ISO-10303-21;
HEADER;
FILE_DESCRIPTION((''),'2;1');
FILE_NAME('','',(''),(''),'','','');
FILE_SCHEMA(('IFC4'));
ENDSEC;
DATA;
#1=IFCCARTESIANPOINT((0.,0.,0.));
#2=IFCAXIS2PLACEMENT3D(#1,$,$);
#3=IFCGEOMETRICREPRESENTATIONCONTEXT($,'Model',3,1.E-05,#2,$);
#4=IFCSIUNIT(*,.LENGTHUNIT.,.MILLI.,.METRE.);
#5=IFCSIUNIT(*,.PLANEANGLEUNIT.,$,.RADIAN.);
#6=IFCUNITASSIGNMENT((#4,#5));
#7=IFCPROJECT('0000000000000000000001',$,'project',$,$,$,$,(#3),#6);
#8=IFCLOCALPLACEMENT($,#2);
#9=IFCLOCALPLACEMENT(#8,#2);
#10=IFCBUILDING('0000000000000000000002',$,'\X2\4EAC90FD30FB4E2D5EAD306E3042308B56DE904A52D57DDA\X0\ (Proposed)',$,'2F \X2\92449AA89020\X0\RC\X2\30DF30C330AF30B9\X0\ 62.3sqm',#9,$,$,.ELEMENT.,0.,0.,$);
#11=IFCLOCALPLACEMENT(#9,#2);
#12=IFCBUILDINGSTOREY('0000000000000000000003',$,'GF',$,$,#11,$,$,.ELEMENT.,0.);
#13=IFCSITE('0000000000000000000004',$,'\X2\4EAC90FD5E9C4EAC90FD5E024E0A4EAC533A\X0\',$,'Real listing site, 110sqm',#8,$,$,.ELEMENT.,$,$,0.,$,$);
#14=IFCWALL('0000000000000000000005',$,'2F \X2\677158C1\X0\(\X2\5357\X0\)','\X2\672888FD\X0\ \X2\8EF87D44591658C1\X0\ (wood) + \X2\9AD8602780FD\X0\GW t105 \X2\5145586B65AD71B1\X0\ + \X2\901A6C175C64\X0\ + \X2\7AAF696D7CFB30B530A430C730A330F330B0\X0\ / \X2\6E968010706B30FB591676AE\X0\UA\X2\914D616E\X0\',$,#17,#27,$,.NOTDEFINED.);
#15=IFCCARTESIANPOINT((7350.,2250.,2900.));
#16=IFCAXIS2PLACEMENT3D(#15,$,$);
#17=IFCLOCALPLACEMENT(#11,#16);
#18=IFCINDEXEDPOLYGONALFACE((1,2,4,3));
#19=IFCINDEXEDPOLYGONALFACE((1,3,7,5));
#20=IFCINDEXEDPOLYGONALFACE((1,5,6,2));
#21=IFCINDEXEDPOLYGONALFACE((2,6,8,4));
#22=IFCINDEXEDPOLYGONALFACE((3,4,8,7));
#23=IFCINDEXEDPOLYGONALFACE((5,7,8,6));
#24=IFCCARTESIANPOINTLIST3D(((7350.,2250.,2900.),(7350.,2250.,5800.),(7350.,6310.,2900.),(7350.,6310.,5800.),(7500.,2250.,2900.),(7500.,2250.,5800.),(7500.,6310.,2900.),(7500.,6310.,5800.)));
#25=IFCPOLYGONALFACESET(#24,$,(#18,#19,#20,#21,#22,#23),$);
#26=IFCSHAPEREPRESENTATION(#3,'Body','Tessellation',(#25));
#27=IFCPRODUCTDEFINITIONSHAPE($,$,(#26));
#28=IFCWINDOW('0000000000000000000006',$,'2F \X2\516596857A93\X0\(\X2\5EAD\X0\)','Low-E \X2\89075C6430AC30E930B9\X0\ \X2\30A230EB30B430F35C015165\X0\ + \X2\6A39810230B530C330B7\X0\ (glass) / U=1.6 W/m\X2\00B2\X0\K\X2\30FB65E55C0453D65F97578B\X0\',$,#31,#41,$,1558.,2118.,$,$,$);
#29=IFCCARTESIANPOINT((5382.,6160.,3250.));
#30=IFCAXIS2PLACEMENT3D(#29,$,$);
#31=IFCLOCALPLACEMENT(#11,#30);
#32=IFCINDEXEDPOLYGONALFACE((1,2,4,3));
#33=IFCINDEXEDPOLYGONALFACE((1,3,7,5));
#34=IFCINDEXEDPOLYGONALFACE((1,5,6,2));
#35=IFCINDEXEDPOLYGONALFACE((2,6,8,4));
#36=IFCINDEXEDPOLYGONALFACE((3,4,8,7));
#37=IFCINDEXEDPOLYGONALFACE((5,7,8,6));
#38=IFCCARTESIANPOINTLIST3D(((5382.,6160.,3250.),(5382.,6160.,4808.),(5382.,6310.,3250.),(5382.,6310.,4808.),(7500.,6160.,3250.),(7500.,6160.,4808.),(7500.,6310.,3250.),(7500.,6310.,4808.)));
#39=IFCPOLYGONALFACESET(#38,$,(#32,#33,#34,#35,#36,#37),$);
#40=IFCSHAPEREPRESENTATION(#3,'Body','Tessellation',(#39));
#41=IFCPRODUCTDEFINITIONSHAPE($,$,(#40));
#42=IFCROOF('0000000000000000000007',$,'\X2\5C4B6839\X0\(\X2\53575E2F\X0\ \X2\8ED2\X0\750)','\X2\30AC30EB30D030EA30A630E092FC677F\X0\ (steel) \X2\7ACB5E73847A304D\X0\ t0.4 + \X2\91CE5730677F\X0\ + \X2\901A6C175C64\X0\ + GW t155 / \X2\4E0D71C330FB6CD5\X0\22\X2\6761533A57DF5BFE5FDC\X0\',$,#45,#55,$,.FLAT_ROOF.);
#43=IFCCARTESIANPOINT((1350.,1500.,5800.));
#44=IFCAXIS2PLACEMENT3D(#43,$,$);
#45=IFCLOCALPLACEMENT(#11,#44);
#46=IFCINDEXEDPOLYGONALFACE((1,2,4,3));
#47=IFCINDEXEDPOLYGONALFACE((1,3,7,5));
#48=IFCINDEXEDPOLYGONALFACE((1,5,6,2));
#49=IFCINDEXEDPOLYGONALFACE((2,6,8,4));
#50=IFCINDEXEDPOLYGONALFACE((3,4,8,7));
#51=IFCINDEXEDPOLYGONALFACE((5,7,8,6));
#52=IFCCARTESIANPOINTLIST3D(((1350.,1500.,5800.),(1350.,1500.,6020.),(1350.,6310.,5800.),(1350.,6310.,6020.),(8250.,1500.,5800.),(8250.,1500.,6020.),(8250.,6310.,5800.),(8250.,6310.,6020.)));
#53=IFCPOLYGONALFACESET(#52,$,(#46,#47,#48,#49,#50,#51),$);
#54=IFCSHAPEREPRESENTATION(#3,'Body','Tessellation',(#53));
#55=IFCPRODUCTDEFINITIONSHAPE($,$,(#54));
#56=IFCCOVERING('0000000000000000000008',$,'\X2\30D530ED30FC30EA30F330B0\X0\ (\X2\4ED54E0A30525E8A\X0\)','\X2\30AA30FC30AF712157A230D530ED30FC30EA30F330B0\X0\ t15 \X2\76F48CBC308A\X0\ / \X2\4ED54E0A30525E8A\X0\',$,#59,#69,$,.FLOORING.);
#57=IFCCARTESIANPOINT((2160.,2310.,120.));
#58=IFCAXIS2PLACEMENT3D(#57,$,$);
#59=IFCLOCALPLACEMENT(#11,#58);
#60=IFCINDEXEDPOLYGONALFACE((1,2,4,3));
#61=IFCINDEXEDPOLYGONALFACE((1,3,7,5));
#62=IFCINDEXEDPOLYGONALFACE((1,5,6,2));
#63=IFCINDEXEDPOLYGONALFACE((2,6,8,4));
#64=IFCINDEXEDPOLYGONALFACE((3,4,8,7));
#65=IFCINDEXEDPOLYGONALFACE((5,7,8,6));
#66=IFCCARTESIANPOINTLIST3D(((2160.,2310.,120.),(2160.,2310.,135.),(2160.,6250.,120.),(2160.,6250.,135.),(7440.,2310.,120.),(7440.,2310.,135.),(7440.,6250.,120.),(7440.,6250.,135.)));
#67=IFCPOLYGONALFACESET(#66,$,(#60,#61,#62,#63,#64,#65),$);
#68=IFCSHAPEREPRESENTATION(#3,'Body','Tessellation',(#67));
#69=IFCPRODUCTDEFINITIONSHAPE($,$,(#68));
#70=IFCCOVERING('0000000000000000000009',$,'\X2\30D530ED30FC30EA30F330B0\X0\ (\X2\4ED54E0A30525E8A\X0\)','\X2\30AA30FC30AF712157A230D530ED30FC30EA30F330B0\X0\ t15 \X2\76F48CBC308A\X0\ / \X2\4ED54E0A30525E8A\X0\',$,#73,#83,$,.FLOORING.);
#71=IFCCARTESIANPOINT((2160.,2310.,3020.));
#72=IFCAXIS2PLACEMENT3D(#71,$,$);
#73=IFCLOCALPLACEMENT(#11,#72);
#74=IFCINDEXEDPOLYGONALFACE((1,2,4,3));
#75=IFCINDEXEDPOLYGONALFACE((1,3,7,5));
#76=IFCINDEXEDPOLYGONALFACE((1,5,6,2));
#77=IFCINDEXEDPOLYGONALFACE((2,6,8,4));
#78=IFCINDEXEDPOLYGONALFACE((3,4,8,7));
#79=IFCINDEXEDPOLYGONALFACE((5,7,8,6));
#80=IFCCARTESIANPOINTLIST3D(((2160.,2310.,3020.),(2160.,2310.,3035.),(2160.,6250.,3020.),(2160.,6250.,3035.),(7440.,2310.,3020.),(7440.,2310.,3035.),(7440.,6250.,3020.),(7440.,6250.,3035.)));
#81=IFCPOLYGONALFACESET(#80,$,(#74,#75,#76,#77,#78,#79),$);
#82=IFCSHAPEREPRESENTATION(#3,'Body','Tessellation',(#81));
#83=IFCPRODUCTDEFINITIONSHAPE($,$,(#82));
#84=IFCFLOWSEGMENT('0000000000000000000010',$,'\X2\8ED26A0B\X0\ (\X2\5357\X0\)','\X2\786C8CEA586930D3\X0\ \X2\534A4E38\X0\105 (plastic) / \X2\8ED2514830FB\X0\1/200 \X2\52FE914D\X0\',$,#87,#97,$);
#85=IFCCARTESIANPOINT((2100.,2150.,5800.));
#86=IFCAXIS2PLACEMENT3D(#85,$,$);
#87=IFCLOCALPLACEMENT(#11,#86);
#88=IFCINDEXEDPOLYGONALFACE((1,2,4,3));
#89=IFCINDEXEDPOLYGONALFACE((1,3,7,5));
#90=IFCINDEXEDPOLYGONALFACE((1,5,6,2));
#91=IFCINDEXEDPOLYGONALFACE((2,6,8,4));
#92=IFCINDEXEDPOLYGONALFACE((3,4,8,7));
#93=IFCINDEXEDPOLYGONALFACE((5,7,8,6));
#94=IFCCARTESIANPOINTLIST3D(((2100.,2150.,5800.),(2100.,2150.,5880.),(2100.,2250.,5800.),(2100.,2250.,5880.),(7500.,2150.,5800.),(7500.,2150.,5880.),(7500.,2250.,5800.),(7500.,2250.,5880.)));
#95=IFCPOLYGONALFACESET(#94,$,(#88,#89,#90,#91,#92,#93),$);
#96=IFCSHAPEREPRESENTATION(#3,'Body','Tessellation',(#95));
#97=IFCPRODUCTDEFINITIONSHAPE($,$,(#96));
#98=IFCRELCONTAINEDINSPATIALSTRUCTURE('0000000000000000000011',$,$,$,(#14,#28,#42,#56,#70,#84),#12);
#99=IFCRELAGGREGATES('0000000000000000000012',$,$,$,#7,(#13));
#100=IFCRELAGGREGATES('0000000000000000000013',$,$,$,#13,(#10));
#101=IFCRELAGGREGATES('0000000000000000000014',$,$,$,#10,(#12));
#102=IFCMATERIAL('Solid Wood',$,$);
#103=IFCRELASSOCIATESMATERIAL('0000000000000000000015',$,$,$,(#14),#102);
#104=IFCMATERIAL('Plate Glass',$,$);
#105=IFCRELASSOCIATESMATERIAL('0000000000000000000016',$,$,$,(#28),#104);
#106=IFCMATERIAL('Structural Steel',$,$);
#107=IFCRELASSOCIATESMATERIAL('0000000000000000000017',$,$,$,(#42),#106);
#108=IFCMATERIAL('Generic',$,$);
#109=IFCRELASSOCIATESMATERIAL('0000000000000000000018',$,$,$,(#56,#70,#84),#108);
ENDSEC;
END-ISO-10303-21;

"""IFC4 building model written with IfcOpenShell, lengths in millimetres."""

from ifc_helpers import new_model, si_unit, frame, frame_2d, origin, place, context, project, spatial, rectangle, extrude, material, element, fill, save


model = new_model("IFC4")

# Units and contexts
model_context = context("Model", 3, precision=1e-05, world=origin())
ifc_project = project(units=[si_unit("LENGTHUNIT", "METRE", prefix="MILLI"), si_unit("PLANEANGLEUNIT", "RADIAN")], contexts=[model_context])

# Site, building, storey
site_placement = place(None, origin())
site = spatial("IfcSite", under=ifc_project, at=site_placement, Name="京都府京都市上京区", ObjectType="Real listing site, 110sqm", CompositionType="ELEMENT", RefElevation=0.0)
building_placement = place(site_placement, origin())
building = spatial("IfcBuilding", under=site, at=building_placement, Name="京都・中庭のある回遊動線 (Proposed)", ObjectType="2F 鉄骨造RCミックス 62.3sqm", CompositionType="ELEMENT", ElevationOfRefHeight=0.0, ElevationOfTerrain=0.0)
storey_placement = place(building_placement, origin())
storey = spatial("IfcBuildingStorey", under=building, at=storey_placement, Name="GF", CompositionType="ELEMENT", Elevation=0.0)

# Shared definitions
ifc_material_1 = material(Name="Solid Wood")

# Wall, opening, window
ifc_material_2 = material(Name="Plate Glass")
wall_1_placement = place(storey_placement, frame((7350.0, 2250.0, 2900.0)))
wall_1 = element("IfcWall", 1, at=wall_1_placement, inside=storey, material=ifc_material_1, Name="2F 東壁(南)", Description="木製 軸組外壁 (wood) + 高性能GW t105 充填断熱 + 通気層 + 窯業系サイディング / 準耐火・外皮UA配慮", PredefinedType="NOTDEFINED", context=model_context, shape_type="SweptSolid", body=[
    extrude(rectangle(XDim=150.0, YDim=4060.0, at=frame_2d((75.0, 2030.0))), frame((7350.0, 2250.0, 2900.0)), (0.0, 0.0, 1.0), 2900.0),
])
opening_1_placement = place(storey_placement, frame((5382.0, 6160.0, 3250.0)))
opening_1 = element("IfcOpeningElement", 2, at=opening_1_placement, cuts=wall_1, PredefinedType="NOTDEFINED", context=model_context, shape_type="SweptSolid", body=[
    extrude(rectangle(XDim=2118.0, YDim=150.0, at=frame_2d((1059.0, 75.0))), frame((5382.0, 6160.0, 3250.0)), (0.0, 0.0, 1.0), 1558.0),
])
window_1_placement = place(storey_placement, frame((5382.0, 6160.0, 3250.0)))
window_1 = element("IfcWindow", 3, at=window_1_placement, inside=storey, material=ifc_material_2, Name="2F 入隅窓(庭)", Description="Low-E 複層ガラス アルゴン封入 + 樹脂サッシ (glass) / U=1.6 W/m²K・日射取得型", OverallHeight=1558.0, OverallWidth=2118.0, context=model_context, shape_type="SweptSolid", body=[
    extrude(rectangle(XDim=2118.0, YDim=150.0, at=frame_2d((1059.0, 75.0))), frame((5382.0, 6160.0, 3250.0)), (0.0, 0.0, 1.0), 1558.0),
])
fill(opening_1, window_1)

# Roof
ifc_material_3 = material(Name="Structural Steel")
for number, where, name in (
    (4, (1350.0, 1500.0, 5800.0), "屋根(南帯 軒750)"),
):
    element("IfcRoof", number, at=place(storey_placement, frame(where)), inside=storey, material=ifc_material_3, Name=name, Description="ガルバリウム鋼板 (steel) 立平葺き t0.4 + 野地板 + 通気層 + GW t155 / 不燃・法22条区域対応", PredefinedType="FLAT_ROOF", context=model_context, shape_type="SweptSolid", body=[
        extrude(rectangle(XDim=6900.0, YDim=4810.0, at=frame_2d((3450.0, 2405.0))), frame((1350.0, 1500.0, 5800.0)), (0.0, 0.0, 1.0), 220.0),
    ])

# Coverings
ifc_material_4 = material(Name="Generic")
covering_1_placement = place(storey_placement, frame((2160.0, 2310.0, 120.0)))
element("IfcCovering", 5, at=covering_1_placement, inside=storey, material=ifc_material_4, Name="フローリング (仕上げ床)", Description="オーク無垢フローリング t15 直貼り / 仕上げ床", PredefinedType="FLOORING", context=model_context, shape_type="SweptSolid", body=[
    extrude(rectangle(XDim=5280.0, YDim=3940.0, at=frame_2d((2640.0, 1970.0))), frame((2160.0, 2310.0, 120.0)), (0.0, 0.0, 1.0), 15.0),
])
covering_2_placement = place(storey_placement, frame((2160.0, 2310.0, 3020.0)))
element("IfcCovering", 6, at=covering_2_placement, inside=storey, material=ifc_material_4, Name="フローリング (仕上げ床)", Description="オーク無垢フローリング t15 直貼り / 仕上げ床", PredefinedType="FLOORING", context=model_context, shape_type="SweptSolid", body=[
    extrude(rectangle(XDim=5280.0, YDim=3940.0, at=frame_2d((2640.0, 1970.0))), frame((2160.0, 2310.0, 3020.0)), (0.0, 0.0, 1.0), 15.0),
])

# Flow segment
flow_segment_placement = place(storey_placement, frame((2100.0, 2150.0, 5800.0)))
element("IfcFlowSegment", 7, at=flow_segment_placement, inside=storey, material=ifc_material_4, Name="軒樋 (南)", Description="硬質塩ビ 半丸105 (plastic) / 軒先・1/200 勾配", context=model_context, shape_type="SweptSolid", body=[
    extrude(rectangle(XDim=5400.0, YDim=100.0, at=frame_2d((2700.0, 50.0))), frame((2100.0, 2150.0, 5800.0)), (0.0, 0.0, 1.0), 80.0),
])

save(model, "model.ifc")
